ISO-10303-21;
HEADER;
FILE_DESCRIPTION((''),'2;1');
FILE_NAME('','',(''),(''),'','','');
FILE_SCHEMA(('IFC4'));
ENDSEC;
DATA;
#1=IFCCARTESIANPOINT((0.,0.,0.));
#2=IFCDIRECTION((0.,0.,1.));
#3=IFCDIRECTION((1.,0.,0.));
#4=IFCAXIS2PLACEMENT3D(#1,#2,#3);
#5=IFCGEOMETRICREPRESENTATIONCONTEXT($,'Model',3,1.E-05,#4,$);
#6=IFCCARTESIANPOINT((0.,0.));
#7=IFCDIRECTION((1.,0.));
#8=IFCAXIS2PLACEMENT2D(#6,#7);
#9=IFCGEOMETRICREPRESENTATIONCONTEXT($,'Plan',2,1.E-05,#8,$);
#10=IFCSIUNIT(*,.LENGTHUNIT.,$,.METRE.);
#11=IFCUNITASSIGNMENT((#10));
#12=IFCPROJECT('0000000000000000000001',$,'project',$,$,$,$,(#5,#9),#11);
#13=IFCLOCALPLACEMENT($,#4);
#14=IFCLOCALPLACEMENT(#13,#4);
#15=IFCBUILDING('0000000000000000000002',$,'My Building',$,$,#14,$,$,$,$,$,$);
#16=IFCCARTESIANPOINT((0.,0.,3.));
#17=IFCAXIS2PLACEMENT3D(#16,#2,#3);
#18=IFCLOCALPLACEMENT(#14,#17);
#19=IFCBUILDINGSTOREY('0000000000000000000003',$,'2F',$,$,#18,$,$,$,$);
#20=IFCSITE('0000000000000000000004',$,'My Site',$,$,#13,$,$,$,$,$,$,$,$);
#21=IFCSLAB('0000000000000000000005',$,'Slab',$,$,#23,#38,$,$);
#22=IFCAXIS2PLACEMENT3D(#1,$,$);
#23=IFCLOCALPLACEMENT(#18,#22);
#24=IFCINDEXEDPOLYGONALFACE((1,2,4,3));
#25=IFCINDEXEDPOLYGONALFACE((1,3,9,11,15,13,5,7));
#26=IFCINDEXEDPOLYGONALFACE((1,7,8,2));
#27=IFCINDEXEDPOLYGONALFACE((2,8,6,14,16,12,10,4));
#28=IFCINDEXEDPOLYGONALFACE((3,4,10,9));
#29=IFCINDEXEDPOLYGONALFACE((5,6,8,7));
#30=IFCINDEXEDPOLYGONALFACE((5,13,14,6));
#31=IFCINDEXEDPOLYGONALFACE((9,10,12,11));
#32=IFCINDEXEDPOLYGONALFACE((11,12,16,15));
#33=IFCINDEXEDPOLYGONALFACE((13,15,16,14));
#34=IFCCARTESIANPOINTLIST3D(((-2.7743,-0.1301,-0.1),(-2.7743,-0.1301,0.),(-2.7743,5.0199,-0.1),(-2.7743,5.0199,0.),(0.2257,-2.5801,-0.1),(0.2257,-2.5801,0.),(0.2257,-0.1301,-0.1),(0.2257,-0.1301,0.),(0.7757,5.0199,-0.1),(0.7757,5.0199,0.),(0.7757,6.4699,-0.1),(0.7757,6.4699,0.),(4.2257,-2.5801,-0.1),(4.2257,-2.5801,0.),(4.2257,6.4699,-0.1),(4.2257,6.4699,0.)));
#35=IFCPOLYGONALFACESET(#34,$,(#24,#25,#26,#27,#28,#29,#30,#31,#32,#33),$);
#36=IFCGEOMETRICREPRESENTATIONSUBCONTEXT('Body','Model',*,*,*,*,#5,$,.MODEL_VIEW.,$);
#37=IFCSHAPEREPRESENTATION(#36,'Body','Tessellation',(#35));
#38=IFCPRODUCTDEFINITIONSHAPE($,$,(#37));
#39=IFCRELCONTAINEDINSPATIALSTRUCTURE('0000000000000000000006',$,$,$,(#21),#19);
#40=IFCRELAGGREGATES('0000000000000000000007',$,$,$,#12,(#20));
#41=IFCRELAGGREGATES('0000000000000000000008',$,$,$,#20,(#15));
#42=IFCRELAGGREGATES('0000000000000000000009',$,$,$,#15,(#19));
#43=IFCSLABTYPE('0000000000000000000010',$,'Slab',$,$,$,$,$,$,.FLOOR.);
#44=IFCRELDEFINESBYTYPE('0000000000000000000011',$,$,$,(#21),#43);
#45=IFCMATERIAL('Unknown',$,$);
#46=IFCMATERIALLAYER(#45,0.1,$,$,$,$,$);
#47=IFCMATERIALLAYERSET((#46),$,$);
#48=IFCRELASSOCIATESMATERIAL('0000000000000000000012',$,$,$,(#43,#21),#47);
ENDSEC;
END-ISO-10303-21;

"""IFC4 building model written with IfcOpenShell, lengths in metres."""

from ifc_helpers import new_model, si_unit, frame, origin_with_axes, origin_2d_with_axis, place, context, subcontext, project, spatial, indexed_curve, outline, extrude, material, layer, layer_set, layer_usage, type_object, element, save


model = new_model("IFC4")

# Units and contexts
model_context = context("Model", 3, precision=1e-05, world=origin_with_axes())
plan_context = context("Plan", 2, precision=1e-05, world=origin_2d_with_axis())
body_context = subcontext(model_context, "Body", "Model", "MODEL_VIEW")
ifc_project = project(units=[si_unit("LENGTHUNIT", "METRE")], contexts=[model_context, plan_context])

# Site, building, storey
site_placement = place(None, origin_with_axes())
site = spatial("IfcSite", under=ifc_project, at=site_placement, Name="My Site")
building_placement = place(site_placement, origin_with_axes())
building = spatial("IfcBuilding", under=site, at=building_placement, Name="My Building")
storey_placement = place(building_placement, frame((0.0, 0.0, 3.0), z_axis=(0.0, 0.0, 1.0), x_axis=(1.0, 0.0, 0.0)))
storey = spatial("IfcBuildingStorey", under=building, at=storey_placement, Name="2F")

# Slab
ifc_material = material(Name="Unknown")
ifc_layer = layer(ifc_material, 0.1)
ifc_layer_set = layer_set([ifc_layer])
ifc_layer_usage = layer_usage(ifc_layer_set, "AXIS3", "POSITIVE", -0.1)
slab_type = type_object("IfcSlabType", Name="Slab", PredefinedType="FLOOR", material=ifc_layer_set)
slab_placement = place(storey_placement, frame((4.2257, 6.4699, 0.0), z_axis=(0.0, 0.0, 1.0), x_axis=(1.0, 0.0, 0.0)))
element("IfcSlab", 1, at=slab_placement, inside=storey, type_object=slab_type, material=ifc_layer_usage, Name="Slab", context=body_context, shape_type="SweptSolid", body=[
    extrude(outline(indexed_curve([(0.0, 0.0), (-3.45, 0.0), (-3.45, -1.45), (-7.0, -1.45), (-7.0, -6.6), (-4.0, -6.6), (-4.0, -9.05), (0.0, -9.05), (0.0, 0.0)])), frame((0.0, 0.0, -0.1), z_axis=(0.0, 0.0, 1.0), x_axis=(1.0, 0.0, 0.0)), (0.0, 0.0, 1.0), 0.1),
])

save(model, "model.ifc")
